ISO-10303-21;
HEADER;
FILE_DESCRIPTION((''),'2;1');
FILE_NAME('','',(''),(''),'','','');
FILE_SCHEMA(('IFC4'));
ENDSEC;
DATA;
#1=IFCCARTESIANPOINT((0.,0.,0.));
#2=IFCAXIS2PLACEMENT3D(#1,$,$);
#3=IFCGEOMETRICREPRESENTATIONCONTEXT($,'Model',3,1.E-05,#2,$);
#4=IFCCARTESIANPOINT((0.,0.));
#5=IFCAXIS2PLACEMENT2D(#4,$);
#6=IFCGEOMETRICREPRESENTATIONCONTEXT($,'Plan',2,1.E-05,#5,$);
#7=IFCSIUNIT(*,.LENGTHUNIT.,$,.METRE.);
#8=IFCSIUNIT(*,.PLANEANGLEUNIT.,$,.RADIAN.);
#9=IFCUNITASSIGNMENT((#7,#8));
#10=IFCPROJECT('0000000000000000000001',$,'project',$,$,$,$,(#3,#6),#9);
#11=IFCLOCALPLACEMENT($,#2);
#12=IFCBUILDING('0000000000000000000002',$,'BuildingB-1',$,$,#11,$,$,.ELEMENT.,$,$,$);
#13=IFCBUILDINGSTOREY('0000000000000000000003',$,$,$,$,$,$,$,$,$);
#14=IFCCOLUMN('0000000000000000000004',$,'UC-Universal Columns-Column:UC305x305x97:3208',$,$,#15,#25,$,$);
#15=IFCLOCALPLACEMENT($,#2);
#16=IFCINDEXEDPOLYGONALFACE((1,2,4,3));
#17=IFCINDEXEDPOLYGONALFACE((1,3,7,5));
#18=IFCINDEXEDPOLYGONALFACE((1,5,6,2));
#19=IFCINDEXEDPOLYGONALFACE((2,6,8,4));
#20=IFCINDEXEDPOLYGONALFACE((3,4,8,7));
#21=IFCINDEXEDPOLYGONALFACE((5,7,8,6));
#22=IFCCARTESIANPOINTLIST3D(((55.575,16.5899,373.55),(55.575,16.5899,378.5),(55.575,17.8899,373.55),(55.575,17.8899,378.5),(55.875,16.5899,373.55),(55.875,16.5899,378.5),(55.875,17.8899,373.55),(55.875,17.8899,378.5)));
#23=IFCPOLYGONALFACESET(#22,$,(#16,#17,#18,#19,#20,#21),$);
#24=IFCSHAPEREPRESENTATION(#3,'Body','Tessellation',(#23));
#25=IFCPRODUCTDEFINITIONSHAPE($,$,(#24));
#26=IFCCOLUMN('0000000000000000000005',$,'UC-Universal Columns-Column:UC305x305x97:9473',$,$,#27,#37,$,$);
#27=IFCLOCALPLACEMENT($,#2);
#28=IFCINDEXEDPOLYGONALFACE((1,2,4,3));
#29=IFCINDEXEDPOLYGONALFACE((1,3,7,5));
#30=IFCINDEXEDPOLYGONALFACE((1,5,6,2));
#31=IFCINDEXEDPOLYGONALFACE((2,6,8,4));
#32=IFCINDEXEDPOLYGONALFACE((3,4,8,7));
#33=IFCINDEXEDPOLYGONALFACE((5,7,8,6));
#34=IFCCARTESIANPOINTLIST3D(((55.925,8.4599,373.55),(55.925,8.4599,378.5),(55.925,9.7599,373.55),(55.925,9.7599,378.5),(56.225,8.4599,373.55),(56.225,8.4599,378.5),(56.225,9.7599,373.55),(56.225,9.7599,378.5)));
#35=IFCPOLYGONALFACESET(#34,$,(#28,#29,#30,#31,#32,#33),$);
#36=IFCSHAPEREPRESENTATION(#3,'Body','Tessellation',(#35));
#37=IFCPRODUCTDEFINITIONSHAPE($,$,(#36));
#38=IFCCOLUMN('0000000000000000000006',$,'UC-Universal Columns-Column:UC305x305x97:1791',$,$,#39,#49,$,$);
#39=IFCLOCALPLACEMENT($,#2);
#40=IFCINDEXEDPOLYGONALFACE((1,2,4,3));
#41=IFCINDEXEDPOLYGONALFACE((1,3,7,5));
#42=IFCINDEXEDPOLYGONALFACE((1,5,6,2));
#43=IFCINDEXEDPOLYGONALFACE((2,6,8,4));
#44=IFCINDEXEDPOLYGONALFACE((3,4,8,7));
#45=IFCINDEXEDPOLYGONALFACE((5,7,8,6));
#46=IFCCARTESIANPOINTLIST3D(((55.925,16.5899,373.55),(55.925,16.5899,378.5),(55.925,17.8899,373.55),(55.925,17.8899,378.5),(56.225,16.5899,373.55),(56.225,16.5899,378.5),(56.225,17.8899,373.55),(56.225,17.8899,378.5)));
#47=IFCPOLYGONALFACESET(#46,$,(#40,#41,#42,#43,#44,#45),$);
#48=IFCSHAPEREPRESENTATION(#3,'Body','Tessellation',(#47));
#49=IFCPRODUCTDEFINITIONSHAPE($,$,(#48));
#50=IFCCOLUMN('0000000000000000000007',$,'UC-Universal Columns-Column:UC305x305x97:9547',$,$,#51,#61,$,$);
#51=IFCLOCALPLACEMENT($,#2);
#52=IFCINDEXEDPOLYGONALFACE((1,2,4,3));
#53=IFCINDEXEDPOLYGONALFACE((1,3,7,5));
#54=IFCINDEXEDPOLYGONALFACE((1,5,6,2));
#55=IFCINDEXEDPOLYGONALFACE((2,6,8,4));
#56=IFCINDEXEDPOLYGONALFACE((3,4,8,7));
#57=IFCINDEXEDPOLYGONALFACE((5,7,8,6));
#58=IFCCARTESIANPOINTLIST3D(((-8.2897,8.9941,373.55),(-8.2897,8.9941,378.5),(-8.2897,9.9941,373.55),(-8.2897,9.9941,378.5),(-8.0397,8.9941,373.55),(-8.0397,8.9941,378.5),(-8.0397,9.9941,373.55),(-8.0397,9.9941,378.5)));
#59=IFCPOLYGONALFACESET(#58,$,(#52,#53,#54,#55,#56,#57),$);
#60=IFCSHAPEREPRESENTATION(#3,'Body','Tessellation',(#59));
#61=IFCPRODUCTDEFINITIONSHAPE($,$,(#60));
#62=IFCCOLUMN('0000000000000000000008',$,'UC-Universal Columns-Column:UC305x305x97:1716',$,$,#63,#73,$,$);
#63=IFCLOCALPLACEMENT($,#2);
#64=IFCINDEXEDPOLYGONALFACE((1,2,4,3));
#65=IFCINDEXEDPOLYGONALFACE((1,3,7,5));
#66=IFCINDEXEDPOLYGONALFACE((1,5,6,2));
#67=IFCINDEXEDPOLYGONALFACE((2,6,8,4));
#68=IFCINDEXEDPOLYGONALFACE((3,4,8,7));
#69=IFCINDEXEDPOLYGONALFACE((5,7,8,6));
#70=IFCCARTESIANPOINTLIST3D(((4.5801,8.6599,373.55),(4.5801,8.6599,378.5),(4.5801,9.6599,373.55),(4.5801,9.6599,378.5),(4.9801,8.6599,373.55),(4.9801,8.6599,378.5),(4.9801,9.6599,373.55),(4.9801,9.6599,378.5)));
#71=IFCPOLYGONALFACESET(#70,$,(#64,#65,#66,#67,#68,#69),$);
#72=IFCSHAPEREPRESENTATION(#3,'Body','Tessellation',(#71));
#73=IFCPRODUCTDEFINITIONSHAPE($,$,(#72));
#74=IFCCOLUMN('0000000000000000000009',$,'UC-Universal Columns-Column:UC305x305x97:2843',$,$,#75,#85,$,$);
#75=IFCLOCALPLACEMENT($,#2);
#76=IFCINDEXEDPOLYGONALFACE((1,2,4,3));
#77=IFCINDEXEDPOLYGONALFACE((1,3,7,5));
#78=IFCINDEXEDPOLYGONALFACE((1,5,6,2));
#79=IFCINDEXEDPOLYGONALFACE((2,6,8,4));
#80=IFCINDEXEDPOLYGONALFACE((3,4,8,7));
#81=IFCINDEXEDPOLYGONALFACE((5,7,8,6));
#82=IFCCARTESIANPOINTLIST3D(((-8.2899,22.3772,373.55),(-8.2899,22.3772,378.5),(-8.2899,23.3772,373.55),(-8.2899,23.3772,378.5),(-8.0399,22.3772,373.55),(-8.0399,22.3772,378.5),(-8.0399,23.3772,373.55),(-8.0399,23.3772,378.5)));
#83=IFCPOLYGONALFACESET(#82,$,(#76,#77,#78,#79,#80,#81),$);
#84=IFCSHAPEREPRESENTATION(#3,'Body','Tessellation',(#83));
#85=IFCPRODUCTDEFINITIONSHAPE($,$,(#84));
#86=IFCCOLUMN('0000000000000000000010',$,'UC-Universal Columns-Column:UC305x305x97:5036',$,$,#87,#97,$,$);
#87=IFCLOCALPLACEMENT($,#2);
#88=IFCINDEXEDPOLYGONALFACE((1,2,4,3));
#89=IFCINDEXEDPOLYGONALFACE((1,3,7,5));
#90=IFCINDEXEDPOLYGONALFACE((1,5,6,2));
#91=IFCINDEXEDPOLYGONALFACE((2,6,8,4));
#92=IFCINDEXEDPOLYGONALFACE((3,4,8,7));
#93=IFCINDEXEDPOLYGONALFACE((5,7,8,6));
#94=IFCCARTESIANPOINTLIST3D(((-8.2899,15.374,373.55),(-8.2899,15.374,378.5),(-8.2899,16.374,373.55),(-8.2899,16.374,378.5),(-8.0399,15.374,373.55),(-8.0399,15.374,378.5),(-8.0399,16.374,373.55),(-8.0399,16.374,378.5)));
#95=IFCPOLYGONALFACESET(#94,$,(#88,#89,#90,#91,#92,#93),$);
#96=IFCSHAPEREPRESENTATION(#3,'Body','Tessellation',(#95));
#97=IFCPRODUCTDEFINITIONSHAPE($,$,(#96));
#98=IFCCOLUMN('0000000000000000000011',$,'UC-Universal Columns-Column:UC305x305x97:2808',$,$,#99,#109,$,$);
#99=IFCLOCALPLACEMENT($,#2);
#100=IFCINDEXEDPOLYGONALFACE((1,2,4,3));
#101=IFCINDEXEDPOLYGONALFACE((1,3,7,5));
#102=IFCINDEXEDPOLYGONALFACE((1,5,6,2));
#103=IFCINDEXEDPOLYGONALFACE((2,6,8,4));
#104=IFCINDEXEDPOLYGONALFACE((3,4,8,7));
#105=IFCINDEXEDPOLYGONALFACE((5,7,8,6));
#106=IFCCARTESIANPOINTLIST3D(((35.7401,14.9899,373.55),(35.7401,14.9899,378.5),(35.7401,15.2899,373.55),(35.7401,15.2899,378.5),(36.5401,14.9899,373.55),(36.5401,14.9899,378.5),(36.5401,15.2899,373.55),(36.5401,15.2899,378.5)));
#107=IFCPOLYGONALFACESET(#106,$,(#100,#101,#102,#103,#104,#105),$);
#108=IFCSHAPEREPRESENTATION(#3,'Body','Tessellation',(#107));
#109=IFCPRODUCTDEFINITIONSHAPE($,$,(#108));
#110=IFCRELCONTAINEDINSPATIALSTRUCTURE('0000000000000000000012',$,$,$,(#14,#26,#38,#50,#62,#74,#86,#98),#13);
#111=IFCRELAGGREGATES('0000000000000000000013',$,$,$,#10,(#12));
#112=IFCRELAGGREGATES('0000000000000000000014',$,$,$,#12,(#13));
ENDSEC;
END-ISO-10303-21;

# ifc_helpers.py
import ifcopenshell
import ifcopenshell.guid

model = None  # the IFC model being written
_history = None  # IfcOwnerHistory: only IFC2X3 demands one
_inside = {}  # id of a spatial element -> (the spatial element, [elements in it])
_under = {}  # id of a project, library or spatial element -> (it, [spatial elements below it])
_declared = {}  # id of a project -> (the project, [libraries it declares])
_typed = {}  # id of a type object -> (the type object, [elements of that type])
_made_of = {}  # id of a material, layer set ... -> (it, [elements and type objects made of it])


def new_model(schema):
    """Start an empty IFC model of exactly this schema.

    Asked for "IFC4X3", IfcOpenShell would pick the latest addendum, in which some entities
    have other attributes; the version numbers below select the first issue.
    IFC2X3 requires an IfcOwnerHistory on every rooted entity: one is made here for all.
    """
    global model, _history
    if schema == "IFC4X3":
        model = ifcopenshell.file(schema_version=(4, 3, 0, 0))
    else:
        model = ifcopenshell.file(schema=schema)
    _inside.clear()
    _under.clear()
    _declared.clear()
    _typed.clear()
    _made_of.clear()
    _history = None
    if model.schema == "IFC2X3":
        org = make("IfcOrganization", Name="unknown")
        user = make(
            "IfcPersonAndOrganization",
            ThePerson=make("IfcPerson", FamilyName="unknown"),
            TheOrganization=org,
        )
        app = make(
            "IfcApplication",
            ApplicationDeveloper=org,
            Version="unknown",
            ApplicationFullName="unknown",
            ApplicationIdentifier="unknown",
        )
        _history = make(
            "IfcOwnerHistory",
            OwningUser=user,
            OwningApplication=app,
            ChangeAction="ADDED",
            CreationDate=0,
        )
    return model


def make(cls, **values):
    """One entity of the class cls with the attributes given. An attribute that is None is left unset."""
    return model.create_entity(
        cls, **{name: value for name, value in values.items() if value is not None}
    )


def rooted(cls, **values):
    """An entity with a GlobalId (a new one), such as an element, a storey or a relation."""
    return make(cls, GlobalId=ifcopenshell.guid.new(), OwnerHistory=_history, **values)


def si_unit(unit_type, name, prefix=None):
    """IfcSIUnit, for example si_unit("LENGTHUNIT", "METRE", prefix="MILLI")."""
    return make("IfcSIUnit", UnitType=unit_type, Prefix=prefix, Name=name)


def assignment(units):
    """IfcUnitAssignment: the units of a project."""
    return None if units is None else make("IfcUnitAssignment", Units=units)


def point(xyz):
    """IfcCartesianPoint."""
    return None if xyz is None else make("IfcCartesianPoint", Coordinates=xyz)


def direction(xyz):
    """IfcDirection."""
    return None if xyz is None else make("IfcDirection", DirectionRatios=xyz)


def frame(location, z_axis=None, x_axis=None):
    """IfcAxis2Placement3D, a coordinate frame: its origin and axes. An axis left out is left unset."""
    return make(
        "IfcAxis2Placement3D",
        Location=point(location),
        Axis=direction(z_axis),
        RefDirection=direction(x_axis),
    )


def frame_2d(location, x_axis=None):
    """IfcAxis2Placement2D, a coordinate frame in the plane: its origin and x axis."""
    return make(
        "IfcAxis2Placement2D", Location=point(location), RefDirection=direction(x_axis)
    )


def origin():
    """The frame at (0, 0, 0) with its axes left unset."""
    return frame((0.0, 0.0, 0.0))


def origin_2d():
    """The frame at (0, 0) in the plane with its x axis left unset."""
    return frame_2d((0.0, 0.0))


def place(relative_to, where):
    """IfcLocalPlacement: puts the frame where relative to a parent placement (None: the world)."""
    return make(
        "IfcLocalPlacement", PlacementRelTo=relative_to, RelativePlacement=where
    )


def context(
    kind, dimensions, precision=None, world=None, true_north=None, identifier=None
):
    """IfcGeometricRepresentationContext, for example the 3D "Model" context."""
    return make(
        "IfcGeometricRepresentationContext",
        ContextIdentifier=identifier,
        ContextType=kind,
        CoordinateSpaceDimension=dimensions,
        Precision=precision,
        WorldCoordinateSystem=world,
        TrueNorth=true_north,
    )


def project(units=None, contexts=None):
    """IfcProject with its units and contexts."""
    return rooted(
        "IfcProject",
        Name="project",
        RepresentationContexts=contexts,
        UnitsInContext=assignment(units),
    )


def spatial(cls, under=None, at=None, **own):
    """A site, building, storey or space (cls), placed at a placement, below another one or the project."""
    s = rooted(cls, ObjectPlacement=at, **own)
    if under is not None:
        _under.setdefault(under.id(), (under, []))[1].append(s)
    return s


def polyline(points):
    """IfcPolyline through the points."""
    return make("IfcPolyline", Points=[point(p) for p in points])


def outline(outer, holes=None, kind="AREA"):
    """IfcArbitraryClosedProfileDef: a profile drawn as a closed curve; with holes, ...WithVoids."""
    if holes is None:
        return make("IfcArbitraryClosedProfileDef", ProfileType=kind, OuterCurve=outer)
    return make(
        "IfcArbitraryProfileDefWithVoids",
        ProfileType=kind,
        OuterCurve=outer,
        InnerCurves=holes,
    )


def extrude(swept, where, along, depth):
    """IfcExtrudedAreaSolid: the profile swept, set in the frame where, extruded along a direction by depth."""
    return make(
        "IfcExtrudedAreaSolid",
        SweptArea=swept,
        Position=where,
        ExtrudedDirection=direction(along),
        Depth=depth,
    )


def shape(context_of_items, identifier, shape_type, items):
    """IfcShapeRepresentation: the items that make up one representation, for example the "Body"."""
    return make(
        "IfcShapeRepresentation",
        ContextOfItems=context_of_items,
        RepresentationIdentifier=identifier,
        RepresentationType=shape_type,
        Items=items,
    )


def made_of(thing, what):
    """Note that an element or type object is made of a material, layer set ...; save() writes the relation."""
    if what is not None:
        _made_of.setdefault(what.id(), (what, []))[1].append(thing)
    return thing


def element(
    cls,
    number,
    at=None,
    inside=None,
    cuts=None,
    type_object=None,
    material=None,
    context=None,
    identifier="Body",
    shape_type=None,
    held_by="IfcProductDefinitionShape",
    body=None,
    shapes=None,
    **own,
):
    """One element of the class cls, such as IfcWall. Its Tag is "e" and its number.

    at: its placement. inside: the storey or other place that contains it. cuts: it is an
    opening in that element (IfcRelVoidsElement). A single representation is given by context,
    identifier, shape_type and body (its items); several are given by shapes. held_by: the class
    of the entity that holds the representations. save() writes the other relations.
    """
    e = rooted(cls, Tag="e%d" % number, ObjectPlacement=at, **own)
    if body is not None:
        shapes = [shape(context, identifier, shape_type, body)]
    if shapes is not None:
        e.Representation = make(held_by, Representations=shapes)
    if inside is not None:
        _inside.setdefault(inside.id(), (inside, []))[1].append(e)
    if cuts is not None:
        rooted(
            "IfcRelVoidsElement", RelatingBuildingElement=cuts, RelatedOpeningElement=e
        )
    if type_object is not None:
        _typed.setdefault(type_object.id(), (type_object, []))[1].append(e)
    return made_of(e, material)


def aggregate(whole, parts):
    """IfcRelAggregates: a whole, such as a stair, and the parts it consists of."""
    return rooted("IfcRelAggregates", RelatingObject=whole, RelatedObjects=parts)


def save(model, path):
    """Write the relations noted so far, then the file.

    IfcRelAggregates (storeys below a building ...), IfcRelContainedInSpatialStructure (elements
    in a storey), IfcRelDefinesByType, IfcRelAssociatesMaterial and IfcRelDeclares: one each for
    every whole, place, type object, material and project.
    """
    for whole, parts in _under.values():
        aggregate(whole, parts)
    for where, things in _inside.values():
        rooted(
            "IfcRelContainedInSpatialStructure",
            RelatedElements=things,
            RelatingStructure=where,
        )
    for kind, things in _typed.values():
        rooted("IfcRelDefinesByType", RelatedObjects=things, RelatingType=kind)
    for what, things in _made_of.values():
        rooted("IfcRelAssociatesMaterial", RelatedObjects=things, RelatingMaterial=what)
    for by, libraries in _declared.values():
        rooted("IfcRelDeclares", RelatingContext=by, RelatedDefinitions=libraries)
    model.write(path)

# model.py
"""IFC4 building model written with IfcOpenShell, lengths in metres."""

from ifc_helpers import new_model, si_unit, origin, origin_2d, place, context, project, spatial, polyline, outline, extrude, element, save


model = new_model("IFC4")

# Units and contexts
model_context = context("Model", 3, precision=1e-05, world=origin())
plan_context = context("Plan", 2, precision=1e-05, world=origin_2d())
ifc_project = project(units=[si_unit("LENGTHUNIT", "METRE"), si_unit("PLANEANGLEUNIT", "RADIAN")], contexts=[model_context, plan_context])

# Building, storey
building_placement = place(None, origin())
building = spatial("IfcBuilding", under=ifc_project, at=building_placement, Name="BuildingB-1", CompositionType="ELEMENT")
storey = spatial("IfcBuildingStorey", under=building)

# Columns
element("IfcColumn", 1, inside=storey, Name="UC-Universal Columns-Column:UC305x305x97:3208", context=model_context, shape_type="SweptSolid", body=[
    extrude(outline(polyline([(55.575, 17.8899, 378.5), (55.575, 16.5899, 378.5), (55.875, 16.5899, 378.5), (55.875, 17.8899, 378.5), (55.575, 17.8899, 378.5)])), None, (0.0, 0.0, -1.0), 4.95),
])
element("IfcColumn", 2, inside=storey, Name="UC-Universal Columns-Column:UC305x305x97:9473", context=model_context, shape_type="SweptSolid", body=[
    extrude(outline(polyline([(55.925, 9.7599, 378.5), (55.925, 8.4599, 378.5), (56.225, 8.4599, 378.5), (56.225, 9.7599, 378.5), (55.925, 9.7599, 378.5)])), None, (0.0, 0.0, -1.0), 4.95),
])
element("IfcColumn", 3, inside=storey, Name="UC-Universal Columns-Column:UC305x305x97:1791", context=model_context, shape_type="SweptSolid", body=[
    extrude(outline(polyline([(55.925, 17.8899, 378.5), (55.925, 16.5899, 378.5), (56.225, 16.5899, 378.5), (56.225, 17.8899, 378.5), (55.925, 17.8899, 378.5)])), None, (0.0, 0.0, -1.0), 4.95),
])
element("IfcColumn", 4, inside=storey, Name="UC-Universal Columns-Column:UC305x305x97:9547", context=model_context, shape_type="SweptSolid", body=[
    extrude(outline(polyline([(-8.0397, 9.9941, 378.5), (-8.2897, 9.9941, 378.5), (-8.2897, 8.9941, 378.5), (-8.0397, 8.9941, 378.5), (-8.0397, 9.9941, 378.5)])), None, (0.0, 0.0, -1.0), 4.95),
])
element("IfcColumn", 5, inside=storey, Name="UC-Universal Columns-Column:UC305x305x97:1716", context=model_context, shape_type="SweptSolid", body=[
    extrude(outline(polyline([(4.5801, 8.6599, 378.5), (4.9801, 8.6599, 378.5), (4.9801, 9.6599, 378.5), (4.5801, 9.6599, 378.5), (4.5801, 8.6599, 378.5)])), None, (0.0, 0.0, -1.0), 4.95),
])
element("IfcColumn", 6, inside=storey, Name="UC-Universal Columns-Column:UC305x305x97:2843", context=model_context, shape_type="SweptSolid", body=[
    extrude(outline(polyline([(-8.0399, 23.3772, 378.5), (-8.2899, 23.3772, 378.5), (-8.2899, 22.3772, 378.5), (-8.0399, 22.3772, 378.5), (-8.0399, 23.3772, 378.5)])), None, (0.0, 0.0, -1.0), 4.95),
])
element("IfcColumn", 7, inside=storey, Name="UC-Universal Columns-Column:UC305x305x97:5036", context=model_context, shape_type="SweptSolid", body=[
    extrude(outline(polyline([(-8.0399, 16.374, 378.5), (-8.2899, 16.374, 378.5), (-8.2899, 15.374, 378.5), (-8.0399, 15.374, 378.5), (-8.0399, 16.374, 378.5)])), None, (0.0, 0.0, -1.0), 4.95),
])
element("IfcColumn", 8, inside=storey, Name="UC-Universal Columns-Column:UC305x305x97:2808", context=model_context, shape_type="SweptSolid", body=[
    extrude(outline(polyline([(36.5401, 15.2899, 378.5), (35.7401, 15.2899, 378.5), (35.7401, 14.9899, 378.5), (36.5401, 14.9899, 378.5), (36.5401, 15.2899, 378.5)])), None, (0.0, 0.0, -1.0), 4.95),
])

save(model, "model.ifc")
